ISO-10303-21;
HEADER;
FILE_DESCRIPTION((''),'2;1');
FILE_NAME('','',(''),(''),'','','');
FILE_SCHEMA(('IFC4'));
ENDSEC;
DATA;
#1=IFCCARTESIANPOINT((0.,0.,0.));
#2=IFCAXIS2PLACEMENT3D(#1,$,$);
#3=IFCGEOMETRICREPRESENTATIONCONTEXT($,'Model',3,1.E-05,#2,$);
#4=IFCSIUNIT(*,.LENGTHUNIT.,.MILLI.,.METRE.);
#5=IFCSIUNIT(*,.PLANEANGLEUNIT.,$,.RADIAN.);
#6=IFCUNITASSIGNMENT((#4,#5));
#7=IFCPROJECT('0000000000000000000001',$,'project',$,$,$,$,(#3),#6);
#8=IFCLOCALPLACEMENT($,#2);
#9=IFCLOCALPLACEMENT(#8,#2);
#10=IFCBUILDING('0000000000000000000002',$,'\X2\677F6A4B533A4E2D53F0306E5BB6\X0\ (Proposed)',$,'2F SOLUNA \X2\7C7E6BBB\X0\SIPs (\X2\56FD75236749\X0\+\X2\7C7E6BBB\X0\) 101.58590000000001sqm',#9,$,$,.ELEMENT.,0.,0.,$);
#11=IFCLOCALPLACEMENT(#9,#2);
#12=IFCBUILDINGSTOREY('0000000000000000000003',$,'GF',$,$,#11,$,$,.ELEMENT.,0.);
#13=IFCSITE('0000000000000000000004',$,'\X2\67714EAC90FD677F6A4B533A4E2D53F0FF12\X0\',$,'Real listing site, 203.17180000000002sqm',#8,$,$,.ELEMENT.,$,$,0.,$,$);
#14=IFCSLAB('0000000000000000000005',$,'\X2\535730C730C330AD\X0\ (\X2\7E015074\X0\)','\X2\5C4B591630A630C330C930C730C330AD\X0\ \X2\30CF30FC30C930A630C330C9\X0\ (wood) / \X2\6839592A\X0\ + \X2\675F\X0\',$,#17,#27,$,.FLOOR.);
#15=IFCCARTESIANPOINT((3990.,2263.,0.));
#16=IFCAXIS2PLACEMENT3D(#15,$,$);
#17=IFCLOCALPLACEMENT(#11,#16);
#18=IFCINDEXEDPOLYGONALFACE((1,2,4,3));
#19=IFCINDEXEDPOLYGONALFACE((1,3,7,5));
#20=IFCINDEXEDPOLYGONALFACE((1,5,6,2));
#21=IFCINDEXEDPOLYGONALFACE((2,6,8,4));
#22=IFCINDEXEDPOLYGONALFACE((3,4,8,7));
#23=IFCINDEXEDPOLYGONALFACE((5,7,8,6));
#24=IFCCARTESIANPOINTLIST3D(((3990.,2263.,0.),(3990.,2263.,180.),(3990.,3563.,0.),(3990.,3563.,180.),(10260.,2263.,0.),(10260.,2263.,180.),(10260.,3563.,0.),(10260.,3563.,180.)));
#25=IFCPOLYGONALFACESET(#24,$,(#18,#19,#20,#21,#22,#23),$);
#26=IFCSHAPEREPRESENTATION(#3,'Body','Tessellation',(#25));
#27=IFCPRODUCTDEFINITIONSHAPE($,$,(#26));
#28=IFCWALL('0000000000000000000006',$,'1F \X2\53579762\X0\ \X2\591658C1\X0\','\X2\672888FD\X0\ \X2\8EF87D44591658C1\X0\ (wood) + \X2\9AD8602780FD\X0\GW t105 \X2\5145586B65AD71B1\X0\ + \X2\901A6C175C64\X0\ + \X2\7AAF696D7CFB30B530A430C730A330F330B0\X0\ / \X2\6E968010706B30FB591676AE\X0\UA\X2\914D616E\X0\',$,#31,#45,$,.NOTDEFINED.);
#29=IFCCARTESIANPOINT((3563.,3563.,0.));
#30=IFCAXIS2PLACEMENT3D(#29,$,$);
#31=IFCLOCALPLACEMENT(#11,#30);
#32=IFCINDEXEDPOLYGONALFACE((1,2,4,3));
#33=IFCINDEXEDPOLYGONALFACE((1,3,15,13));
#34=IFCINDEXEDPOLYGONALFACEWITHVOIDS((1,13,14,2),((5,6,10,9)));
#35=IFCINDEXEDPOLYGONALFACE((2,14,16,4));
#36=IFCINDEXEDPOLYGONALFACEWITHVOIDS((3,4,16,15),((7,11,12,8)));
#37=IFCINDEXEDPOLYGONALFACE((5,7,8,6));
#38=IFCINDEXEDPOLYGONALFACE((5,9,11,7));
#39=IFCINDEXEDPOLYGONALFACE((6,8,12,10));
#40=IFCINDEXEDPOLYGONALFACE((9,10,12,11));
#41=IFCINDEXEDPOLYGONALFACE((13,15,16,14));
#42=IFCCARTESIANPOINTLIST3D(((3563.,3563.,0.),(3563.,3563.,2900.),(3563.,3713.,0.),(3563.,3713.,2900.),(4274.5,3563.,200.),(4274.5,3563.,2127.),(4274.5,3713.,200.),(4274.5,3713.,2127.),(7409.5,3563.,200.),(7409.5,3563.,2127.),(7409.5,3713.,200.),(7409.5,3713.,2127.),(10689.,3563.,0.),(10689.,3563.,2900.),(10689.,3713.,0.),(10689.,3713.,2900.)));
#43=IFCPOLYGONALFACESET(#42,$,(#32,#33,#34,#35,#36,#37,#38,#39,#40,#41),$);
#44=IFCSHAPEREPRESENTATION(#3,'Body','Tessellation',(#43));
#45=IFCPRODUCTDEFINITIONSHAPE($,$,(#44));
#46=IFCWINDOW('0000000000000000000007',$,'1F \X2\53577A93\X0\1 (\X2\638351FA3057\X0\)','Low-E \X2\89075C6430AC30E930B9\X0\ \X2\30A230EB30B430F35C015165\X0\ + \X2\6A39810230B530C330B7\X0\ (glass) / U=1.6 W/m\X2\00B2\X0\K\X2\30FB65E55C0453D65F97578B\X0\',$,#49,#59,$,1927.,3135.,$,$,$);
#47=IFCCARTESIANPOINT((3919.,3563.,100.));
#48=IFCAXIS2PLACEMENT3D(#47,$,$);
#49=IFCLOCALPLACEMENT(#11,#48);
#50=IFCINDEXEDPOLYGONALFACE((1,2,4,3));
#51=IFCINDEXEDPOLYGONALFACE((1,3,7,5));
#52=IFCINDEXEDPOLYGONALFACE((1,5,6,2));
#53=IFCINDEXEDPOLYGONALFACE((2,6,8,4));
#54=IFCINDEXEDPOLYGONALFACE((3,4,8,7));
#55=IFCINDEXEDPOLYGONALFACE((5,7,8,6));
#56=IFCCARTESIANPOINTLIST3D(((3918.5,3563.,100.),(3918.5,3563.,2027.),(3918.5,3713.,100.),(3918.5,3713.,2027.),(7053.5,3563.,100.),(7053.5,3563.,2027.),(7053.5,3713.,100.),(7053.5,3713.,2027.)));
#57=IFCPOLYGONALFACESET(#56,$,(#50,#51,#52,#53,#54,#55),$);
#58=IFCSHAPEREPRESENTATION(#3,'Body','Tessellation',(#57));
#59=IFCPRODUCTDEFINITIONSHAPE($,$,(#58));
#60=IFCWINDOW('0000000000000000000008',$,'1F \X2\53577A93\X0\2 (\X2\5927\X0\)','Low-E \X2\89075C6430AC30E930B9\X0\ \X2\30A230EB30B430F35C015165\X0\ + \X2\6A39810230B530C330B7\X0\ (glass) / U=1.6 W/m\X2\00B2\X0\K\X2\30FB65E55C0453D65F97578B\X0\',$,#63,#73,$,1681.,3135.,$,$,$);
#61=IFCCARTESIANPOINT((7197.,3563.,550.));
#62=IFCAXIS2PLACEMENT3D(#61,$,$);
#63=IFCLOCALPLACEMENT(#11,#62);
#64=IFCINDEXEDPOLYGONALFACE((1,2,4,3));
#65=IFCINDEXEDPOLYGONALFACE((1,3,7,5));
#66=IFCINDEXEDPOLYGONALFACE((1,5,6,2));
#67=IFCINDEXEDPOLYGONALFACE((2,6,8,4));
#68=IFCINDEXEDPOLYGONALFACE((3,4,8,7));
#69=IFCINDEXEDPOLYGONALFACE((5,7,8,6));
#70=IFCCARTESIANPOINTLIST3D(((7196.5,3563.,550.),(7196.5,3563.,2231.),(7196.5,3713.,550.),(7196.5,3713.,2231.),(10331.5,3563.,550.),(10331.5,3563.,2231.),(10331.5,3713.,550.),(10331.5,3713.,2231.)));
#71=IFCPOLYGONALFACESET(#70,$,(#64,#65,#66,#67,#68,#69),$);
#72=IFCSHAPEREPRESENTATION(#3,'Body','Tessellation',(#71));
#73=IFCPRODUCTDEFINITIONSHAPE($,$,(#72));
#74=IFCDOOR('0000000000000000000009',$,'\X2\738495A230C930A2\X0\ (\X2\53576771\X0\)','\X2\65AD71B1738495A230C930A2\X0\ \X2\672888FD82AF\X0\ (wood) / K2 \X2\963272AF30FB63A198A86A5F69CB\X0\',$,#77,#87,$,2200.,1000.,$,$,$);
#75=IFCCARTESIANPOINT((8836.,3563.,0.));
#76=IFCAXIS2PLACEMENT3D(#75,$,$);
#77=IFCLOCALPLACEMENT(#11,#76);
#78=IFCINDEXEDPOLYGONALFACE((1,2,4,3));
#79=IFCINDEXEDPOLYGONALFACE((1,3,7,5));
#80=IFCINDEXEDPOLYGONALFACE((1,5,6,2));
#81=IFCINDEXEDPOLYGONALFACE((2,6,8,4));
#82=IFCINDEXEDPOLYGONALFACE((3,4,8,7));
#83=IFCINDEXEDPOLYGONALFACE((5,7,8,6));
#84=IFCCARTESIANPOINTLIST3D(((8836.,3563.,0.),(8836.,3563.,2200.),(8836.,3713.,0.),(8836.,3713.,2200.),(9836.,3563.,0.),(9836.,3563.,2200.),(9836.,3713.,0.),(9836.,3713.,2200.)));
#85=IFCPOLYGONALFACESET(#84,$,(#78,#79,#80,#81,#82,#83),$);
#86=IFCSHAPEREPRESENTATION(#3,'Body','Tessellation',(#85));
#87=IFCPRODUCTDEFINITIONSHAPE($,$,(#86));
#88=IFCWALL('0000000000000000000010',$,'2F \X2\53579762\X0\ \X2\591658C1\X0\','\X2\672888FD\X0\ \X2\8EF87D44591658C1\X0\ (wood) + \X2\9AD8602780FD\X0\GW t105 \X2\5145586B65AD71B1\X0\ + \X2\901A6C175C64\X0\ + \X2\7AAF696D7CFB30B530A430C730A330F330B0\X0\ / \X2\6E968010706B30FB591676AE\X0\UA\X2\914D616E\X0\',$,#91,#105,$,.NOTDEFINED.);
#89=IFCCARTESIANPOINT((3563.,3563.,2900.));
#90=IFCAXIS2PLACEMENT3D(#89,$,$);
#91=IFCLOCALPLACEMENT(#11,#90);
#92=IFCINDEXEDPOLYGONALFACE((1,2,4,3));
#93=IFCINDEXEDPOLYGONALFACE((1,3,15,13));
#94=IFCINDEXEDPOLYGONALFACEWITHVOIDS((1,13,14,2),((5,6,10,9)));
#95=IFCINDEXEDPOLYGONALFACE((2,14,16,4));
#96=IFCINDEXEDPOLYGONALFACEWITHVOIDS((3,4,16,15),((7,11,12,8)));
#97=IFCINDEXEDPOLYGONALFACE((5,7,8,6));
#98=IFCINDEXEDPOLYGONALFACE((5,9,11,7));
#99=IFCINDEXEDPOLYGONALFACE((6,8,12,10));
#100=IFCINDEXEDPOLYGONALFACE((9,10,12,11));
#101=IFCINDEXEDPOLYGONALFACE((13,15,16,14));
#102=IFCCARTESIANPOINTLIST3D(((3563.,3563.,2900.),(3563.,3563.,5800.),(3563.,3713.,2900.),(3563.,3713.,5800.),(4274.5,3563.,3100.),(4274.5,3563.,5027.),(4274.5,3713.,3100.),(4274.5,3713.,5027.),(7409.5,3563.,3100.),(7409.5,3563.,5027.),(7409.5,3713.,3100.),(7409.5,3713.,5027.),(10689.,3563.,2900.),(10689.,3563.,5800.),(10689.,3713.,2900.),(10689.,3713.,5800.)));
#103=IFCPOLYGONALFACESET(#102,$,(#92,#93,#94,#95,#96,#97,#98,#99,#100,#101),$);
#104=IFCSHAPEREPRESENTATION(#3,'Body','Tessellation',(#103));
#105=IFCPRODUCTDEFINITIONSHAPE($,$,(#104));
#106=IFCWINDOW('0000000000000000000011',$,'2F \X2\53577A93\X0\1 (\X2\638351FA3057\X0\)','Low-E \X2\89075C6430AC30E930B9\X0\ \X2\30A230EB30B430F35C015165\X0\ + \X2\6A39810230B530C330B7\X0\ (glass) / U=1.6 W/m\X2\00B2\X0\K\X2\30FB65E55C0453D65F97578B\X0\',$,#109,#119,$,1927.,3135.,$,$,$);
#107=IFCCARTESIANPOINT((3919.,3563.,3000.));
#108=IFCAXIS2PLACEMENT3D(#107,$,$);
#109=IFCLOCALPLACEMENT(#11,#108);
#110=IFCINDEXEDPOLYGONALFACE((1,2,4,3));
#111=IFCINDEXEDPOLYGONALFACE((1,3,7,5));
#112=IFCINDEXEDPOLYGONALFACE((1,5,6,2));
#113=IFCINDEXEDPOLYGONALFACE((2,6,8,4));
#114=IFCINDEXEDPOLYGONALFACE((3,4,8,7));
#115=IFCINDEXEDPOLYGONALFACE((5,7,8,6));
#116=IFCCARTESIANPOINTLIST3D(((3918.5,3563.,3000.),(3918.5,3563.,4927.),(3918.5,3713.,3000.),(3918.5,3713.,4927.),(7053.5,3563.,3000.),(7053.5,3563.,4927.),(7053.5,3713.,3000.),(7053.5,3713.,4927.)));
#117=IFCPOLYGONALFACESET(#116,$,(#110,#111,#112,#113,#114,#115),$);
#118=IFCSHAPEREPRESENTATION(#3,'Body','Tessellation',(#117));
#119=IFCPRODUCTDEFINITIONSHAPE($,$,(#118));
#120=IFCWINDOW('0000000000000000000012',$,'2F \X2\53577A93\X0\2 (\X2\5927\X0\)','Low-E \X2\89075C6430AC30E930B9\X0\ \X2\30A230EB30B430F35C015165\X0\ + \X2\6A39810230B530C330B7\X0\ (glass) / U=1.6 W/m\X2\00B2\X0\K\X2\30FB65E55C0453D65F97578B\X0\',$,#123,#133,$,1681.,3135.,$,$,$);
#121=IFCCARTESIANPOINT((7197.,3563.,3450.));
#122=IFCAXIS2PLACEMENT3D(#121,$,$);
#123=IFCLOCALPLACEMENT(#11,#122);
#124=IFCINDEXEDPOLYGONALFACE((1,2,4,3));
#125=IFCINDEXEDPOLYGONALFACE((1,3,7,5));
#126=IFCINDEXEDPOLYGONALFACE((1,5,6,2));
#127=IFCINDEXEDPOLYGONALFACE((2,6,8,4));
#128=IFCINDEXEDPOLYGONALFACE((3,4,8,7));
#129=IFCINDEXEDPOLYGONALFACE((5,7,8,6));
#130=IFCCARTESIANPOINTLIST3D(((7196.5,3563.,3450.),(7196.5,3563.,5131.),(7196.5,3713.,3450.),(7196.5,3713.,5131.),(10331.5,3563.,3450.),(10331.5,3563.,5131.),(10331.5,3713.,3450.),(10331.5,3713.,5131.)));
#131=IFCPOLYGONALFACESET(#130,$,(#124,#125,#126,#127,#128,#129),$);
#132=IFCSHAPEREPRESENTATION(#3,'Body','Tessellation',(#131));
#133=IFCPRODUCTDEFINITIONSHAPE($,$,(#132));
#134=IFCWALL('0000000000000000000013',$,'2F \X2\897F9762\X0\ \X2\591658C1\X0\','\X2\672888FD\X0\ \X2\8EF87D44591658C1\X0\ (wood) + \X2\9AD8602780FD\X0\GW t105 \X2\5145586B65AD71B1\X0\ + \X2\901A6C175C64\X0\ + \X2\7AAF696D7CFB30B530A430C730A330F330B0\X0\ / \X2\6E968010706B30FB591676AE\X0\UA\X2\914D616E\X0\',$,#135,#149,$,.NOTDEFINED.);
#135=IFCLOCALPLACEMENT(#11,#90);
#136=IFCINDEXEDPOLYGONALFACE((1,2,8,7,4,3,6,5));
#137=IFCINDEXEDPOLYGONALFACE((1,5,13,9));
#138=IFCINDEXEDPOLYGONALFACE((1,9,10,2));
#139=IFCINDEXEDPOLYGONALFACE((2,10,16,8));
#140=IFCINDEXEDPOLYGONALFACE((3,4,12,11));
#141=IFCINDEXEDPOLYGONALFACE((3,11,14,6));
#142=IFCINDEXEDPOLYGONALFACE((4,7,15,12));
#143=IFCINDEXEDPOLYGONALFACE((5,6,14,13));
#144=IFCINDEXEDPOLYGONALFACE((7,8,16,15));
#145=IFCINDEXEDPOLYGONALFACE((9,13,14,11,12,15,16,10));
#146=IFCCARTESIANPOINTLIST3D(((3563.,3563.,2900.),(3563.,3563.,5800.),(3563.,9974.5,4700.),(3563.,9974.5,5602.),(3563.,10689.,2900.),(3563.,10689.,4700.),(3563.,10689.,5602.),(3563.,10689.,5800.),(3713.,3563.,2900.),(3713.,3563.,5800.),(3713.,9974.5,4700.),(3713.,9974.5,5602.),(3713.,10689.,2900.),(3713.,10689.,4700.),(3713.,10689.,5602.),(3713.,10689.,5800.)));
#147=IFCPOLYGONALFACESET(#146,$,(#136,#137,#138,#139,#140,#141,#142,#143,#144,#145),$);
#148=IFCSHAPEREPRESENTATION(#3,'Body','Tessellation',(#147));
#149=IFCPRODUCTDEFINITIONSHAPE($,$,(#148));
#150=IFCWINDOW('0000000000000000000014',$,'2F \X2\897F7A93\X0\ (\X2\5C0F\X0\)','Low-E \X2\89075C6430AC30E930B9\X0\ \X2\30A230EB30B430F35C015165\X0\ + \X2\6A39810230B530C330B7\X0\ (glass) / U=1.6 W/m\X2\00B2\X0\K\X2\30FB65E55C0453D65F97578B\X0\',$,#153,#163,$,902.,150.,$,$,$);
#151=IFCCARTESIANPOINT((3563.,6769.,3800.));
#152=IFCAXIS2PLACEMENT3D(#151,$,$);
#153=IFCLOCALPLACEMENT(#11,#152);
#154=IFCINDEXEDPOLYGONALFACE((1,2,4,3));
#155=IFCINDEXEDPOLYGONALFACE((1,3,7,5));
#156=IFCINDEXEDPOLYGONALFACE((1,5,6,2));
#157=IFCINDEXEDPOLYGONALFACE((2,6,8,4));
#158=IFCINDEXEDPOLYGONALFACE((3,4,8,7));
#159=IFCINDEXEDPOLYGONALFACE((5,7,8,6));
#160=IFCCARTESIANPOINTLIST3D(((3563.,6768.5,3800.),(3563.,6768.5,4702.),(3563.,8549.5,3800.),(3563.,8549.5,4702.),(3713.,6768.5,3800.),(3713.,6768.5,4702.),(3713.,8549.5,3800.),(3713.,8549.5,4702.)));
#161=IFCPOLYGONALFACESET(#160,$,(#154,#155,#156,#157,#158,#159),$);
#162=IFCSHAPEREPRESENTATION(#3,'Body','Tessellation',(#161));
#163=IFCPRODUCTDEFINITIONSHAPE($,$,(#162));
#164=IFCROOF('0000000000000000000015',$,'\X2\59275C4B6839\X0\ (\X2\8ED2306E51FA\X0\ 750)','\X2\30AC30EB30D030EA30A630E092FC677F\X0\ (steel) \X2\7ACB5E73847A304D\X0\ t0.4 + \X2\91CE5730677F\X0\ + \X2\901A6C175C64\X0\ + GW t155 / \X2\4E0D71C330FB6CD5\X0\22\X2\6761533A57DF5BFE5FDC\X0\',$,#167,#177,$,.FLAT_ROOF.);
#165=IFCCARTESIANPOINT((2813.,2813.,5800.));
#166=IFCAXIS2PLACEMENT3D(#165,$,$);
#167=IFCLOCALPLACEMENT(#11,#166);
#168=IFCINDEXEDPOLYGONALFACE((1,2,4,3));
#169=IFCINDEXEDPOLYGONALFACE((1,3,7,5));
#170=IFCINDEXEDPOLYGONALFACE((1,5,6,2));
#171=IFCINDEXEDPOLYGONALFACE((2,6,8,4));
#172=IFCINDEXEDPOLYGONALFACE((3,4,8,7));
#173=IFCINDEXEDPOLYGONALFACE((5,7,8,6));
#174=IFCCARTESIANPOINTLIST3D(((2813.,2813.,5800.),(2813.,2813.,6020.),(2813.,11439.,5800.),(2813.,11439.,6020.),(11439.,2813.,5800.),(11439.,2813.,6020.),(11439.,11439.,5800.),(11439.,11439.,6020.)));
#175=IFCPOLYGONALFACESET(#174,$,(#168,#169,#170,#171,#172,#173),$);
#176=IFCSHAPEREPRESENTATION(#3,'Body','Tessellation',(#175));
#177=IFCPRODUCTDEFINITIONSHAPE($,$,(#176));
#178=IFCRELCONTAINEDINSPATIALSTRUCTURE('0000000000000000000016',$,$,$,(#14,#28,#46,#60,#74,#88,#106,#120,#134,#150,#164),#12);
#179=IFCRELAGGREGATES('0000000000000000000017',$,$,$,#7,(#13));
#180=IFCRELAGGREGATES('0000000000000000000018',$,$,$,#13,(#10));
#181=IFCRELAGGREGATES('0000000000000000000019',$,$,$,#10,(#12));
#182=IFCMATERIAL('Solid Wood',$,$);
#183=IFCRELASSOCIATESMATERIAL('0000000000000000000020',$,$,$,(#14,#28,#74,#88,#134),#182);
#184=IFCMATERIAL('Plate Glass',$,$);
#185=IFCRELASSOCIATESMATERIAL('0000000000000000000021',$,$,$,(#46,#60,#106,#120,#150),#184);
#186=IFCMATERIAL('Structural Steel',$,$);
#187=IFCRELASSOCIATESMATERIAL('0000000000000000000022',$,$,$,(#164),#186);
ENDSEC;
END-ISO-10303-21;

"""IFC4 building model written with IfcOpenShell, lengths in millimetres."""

from ifc_helpers import new_model, si_unit, frame, frame_2d, origin, place, context, project, spatial, rectangle, extrude, material, element, fill, save


model = new_model("IFC4")

# Units and contexts
model_context = context("Model", 3, precision=1e-05, world=origin())
ifc_project = project(units=[si_unit("LENGTHUNIT", "METRE", prefix="MILLI"), si_unit("PLANEANGLEUNIT", "RADIAN")], contexts=[model_context])

# Site, building, storey
site_placement = place(None, origin())
site = spatial("IfcSite", under=ifc_project, at=site_placement, Name="東京都板橋区中台２", ObjectType="Real listing site, 203.17180000000002sqm", CompositionType="ELEMENT", RefElevation=0.0)
building_placement = place(site_placement, origin())
building = spatial("IfcBuilding", under=site, at=building_placement, Name="板橋区中台の家 (Proposed)", ObjectType="2F SOLUNA 籾殻SIPs (国産杉+籾殻) 101.58590000000001sqm", CompositionType="ELEMENT", ElevationOfRefHeight=0.0, ElevationOfTerrain=0.0)
storey_placement = place(building_placement, origin())
storey = spatial("IfcBuildingStorey", under=building, at=storey_placement, Name="GF", CompositionType="ELEMENT", Elevation=0.0)

# Slab
ifc_material_1 = material(Name="Solid Wood")
slab_1_placement = place(storey_placement, frame((3990.0, 2263.0, 0.0)))
element("IfcSlab", 1, at=slab_1_placement, inside=storey, material=ifc_material_1, Name="南デッキ (縁側)", Description="屋外ウッドデッキ ハードウッド (wood) / 根太 + 束", PredefinedType="FLOOR", context=model_context, shape_type="SweptSolid", body=[
    extrude(rectangle(XDim=6270.0, YDim=1300.0, at=frame_2d((3135.0, 650.0))), frame((3990.0, 2263.0, 0.0)), (0.0, 0.0, 1.0), 180.0),
])

# Wall, openings, windows, door
wall_1_placement = place(storey_placement, frame((3563.0, 3563.0, 0.0)))
wall_1 = element("IfcWall", 2, at=wall_1_placement, inside=storey, material=ifc_material_1, Name="1F 南面 外壁", Description="木製 軸組外壁 (wood) + 高性能GW t105 充填断熱 + 通気層 + 窯業系サイディング / 準耐火・外皮UA配慮", PredefinedType="NOTDEFINED", context=model_context, shape_type="SweptSolid", body=[
    extrude(rectangle(XDim=7126.0, YDim=150.0, at=frame_2d((3563.0, 75.0))), frame((3563.0, 3563.0, 0.0)), (0.0, 0.0, 1.0), 2900.0),
])
opening_1_placement = place(storey_placement, frame((3919.0, 3563.0, 100.0)))
opening_1 = element("IfcOpeningElement", 3, at=opening_1_placement, cuts=wall_1, PredefinedType="NOTDEFINED", context=model_context, shape_type="SweptSolid", body=[
    extrude(rectangle(XDim=3135.0, YDim=150.0, at=frame_2d((1567.0, 75.0))), frame((3919.0, 3563.0, 100.0)), (0.0, 0.0, 1.0), 1927.0),
])
opening_2_placement = place(storey_placement, frame((7197.0, 3563.0, 550.0)))
opening_2 = element("IfcOpeningElement", 4, at=opening_2_placement, cuts=wall_1, PredefinedType="NOTDEFINED", context=model_context, shape_type="SweptSolid", body=[
    extrude(rectangle(XDim=3135.0, YDim=150.0, at=frame_2d((1567.0, 75.0))), frame((7197.0, 3563.0, 550.0)), (0.0, 0.0, 1.0), 1681.0),
])
opening_3_placement = place(storey_placement, frame((8836.0, 3563.0, 0.0)))
opening_3 = element("IfcOpeningElement", 5, at=opening_3_placement, cuts=wall_1, PredefinedType="NOTDEFINED", context=model_context, shape_type="SweptSolid", body=[
    extrude(rectangle(XDim=1000.0, YDim=150.0, at=frame_2d((500.0, 75.0))), frame((8836.0, 3563.0, 0.0)), (0.0, 0.0, 1.0), 2200.0),
])
ifc_material_2 = material(Name="Plate Glass")
window_1_placement = place(storey_placement, frame((3919.0, 3563.0, 100.0)))
window_1 = element("IfcWindow", 6, at=window_1_placement, inside=storey, material=ifc_material_2, Name="1F 南窓1 (掃出し)", Description="Low-E 複層ガラス アルゴン封入 + 樹脂サッシ (glass) / U=1.6 W/m²K・日射取得型", OverallHeight=1927.0, OverallWidth=3135.0, context=model_context, shape_type="SweptSolid", body=[
    extrude(rectangle(XDim=3135.0, YDim=150.0, at=frame_2d((1567.0, 75.0))), frame((3919.0, 3563.0, 100.0)), (0.0, 0.0, 1.0), 1927.0),
])
fill(opening_1, window_1)
window_2_placement = place(storey_placement, frame((7197.0, 3563.0, 550.0)))
window_2 = element("IfcWindow", 7, at=window_2_placement, inside=storey, material=ifc_material_2, Name="1F 南窓2 (大)", Description="Low-E 複層ガラス アルゴン封入 + 樹脂サッシ (glass) / U=1.6 W/m²K・日射取得型", OverallHeight=1681.0, OverallWidth=3135.0, context=model_context, shape_type="SweptSolid", body=[
    extrude(rectangle(XDim=3135.0, YDim=150.0, at=frame_2d((1567.0, 75.0))), frame((7197.0, 3563.0, 550.0)), (0.0, 0.0, 1.0), 1681.0),
])
fill(opening_2, window_2)
door_placement = place(storey_placement, frame((8836.0, 3563.0, 0.0)))
door = element("IfcDoor", 8, at=door_placement, inside=storey, material=ifc_material_1, Name="玄関ドア (南東)", Description="断熱玄関ドア 木製芯 (wood) / K2 防犯・採風機構", OverallHeight=2200.0, OverallWidth=1000.0, context=model_context, shape_type="SweptSolid", body=[
    extrude(rectangle(XDim=1000.0, YDim=150.0, at=frame_2d((500.0, 75.0))), frame((8836.0, 3563.0, 0.0)), (0.0, 0.0, 1.0), 2200.0),
])
fill(opening_3, door)

# Wall, openings, windows
wall_2_placement = place(storey_placement, frame((3563.0, 3563.0, 2900.0)))
wall_2 = element("IfcWall", 9, at=wall_2_placement, inside=storey, material=ifc_material_1, Name="2F 南面 外壁", Description="木製 軸組外壁 (wood) + 高性能GW t105 充填断熱 + 通気層 + 窯業系サイディング / 準耐火・外皮UA配慮", PredefinedType="NOTDEFINED", context=model_context, shape_type="SweptSolid", body=[
    extrude(rectangle(XDim=7126.0, YDim=150.0, at=frame_2d((3563.0, 75.0))), frame((3563.0, 3563.0, 2900.0)), (0.0, 0.0, 1.0), 2900.0),
])
opening_4_placement = place(storey_placement, frame((3919.0, 3563.0, 3000.0)))
opening_4 = element("IfcOpeningElement", 10, at=opening_4_placement, cuts=wall_2, PredefinedType="NOTDEFINED", context=model_context, shape_type="SweptSolid", body=[
    extrude(rectangle(XDim=3135.0, YDim=150.0, at=frame_2d((1567.0, 75.0))), frame((3919.0, 3563.0, 3000.0)), (0.0, 0.0, 1.0), 1927.0),
])
opening_5_placement = place(storey_placement, frame((7197.0, 3563.0, 3450.0)))
opening_5 = element("IfcOpeningElement", 11, at=opening_5_placement, cuts=wall_2, PredefinedType="NOTDEFINED", context=model_context, shape_type="SweptSolid", body=[
    extrude(rectangle(XDim=3135.0, YDim=150.0, at=frame_2d((1567.0, 75.0))), frame((7197.0, 3563.0, 3450.0)), (0.0, 0.0, 1.0), 1681.0),
])
window_3_placement = place(storey_placement, frame((3919.0, 3563.0, 3000.0)))
window_3 = element("IfcWindow", 12, at=window_3_placement, inside=storey, material=ifc_material_2, Name="2F 南窓1 (掃出し)", Description="Low-E 複層ガラス アルゴン封入 + 樹脂サッシ (glass) / U=1.6 W/m²K・日射取得型", OverallHeight=1927.0, OverallWidth=3135.0, context=model_context, shape_type="SweptSolid", body=[
    extrude(rectangle(XDim=3135.0, YDim=150.0, at=frame_2d((1567.0, 75.0))), frame((3919.0, 3563.0, 3000.0)), (0.0, 0.0, 1.0), 1927.0),
])
fill(opening_4, window_3)
window_4_placement = place(storey_placement, frame((7197.0, 3563.0, 3450.0)))
window_4 = element("IfcWindow", 13, at=window_4_placement, inside=storey, material=ifc_material_2, Name="2F 南窓2 (大)", Description="Low-E 複層ガラス アルゴン封入 + 樹脂サッシ (glass) / U=1.6 W/m²K・日射取得型", OverallHeight=1681.0, OverallWidth=3135.0, context=model_context, shape_type="SweptSolid", body=[
    extrude(rectangle(XDim=3135.0, YDim=150.0, at=frame_2d((1567.0, 75.0))), frame((7197.0, 3563.0, 3450.0)), (0.0, 0.0, 1.0), 1681.0),
])
fill(opening_5, window_4)

# Wall, opening, window
wall_3_placement = place(storey_placement, frame((3563.0, 3563.0, 2900.0)))
wall_3 = element("IfcWall", 14, at=wall_3_placement, inside=storey, material=ifc_material_1, Name="2F 西面 外壁", Description="木製 軸組外壁 (wood) + 高性能GW t105 充填断熱 + 通気層 + 窯業系サイディング / 準耐火・外皮UA配慮", PredefinedType="NOTDEFINED", context=model_context, shape_type="SweptSolid", body=[
    extrude(rectangle(XDim=150.0, YDim=7126.0, at=frame_2d((75.0, 3563.0))), frame((3563.0, 3563.0, 2900.0)), (0.0, 0.0, 1.0), 2900.0),
])
opening_6_placement = place(storey_placement, frame((3563.0, 6769.0, 3800.0)))
opening_6 = element("IfcOpeningElement", 15, at=opening_6_placement, cuts=wall_3, PredefinedType="NOTDEFINED", context=model_context, shape_type="SweptSolid", body=[
    extrude(rectangle(XDim=150.0, YDim=1781.0, at=frame_2d((75.0, 890.0))), frame((3563.0, 6769.0, 3800.0)), (0.0, 0.0, 1.0), 902.0),
])
window_5_placement = place(storey_placement, frame((3563.0, 6769.0, 3800.0)))
window_5 = element("IfcWindow", 16, at=window_5_placement, inside=storey, material=ifc_material_2, Name="2F 西窓 (小)", Description="Low-E 複層ガラス アルゴン封入 + 樹脂サッシ (glass) / U=1.6 W/m²K・日射取得型", OverallHeight=902.0, OverallWidth=150.0, context=model_context, shape_type="SweptSolid", body=[
    extrude(rectangle(XDim=150.0, YDim=1781.0, at=frame_2d((75.0, 890.0))), frame((3563.0, 6769.0, 3800.0)), (0.0, 0.0, 1.0), 902.0),
])
fill(opening_6, window_5)

# Roof
ifc_material_3 = material(Name="Structural Steel")
roof_placement = place(storey_placement, frame((2813.0, 2813.0, 5800.0)))
element("IfcRoof", 17, at=roof_placement, inside=storey, material=ifc_material_3, Name="大屋根 (軒の出 750)", Description="ガルバリウム鋼板 (steel) 立平葺き t0.4 + 野地板 + 通気層 + GW t155 / 不燃・法22条区域対応", PredefinedType="FLAT_ROOF", context=model_context, shape_type="SweptSolid", body=[
    extrude(rectangle(XDim=8626.0, YDim=8626.0, at=frame_2d((4313.0, 4313.0))), frame((2813.0, 2813.0, 5800.0)), (0.0, 0.0, 1.0), 220.0),
])

save(model, "model.ifc")
